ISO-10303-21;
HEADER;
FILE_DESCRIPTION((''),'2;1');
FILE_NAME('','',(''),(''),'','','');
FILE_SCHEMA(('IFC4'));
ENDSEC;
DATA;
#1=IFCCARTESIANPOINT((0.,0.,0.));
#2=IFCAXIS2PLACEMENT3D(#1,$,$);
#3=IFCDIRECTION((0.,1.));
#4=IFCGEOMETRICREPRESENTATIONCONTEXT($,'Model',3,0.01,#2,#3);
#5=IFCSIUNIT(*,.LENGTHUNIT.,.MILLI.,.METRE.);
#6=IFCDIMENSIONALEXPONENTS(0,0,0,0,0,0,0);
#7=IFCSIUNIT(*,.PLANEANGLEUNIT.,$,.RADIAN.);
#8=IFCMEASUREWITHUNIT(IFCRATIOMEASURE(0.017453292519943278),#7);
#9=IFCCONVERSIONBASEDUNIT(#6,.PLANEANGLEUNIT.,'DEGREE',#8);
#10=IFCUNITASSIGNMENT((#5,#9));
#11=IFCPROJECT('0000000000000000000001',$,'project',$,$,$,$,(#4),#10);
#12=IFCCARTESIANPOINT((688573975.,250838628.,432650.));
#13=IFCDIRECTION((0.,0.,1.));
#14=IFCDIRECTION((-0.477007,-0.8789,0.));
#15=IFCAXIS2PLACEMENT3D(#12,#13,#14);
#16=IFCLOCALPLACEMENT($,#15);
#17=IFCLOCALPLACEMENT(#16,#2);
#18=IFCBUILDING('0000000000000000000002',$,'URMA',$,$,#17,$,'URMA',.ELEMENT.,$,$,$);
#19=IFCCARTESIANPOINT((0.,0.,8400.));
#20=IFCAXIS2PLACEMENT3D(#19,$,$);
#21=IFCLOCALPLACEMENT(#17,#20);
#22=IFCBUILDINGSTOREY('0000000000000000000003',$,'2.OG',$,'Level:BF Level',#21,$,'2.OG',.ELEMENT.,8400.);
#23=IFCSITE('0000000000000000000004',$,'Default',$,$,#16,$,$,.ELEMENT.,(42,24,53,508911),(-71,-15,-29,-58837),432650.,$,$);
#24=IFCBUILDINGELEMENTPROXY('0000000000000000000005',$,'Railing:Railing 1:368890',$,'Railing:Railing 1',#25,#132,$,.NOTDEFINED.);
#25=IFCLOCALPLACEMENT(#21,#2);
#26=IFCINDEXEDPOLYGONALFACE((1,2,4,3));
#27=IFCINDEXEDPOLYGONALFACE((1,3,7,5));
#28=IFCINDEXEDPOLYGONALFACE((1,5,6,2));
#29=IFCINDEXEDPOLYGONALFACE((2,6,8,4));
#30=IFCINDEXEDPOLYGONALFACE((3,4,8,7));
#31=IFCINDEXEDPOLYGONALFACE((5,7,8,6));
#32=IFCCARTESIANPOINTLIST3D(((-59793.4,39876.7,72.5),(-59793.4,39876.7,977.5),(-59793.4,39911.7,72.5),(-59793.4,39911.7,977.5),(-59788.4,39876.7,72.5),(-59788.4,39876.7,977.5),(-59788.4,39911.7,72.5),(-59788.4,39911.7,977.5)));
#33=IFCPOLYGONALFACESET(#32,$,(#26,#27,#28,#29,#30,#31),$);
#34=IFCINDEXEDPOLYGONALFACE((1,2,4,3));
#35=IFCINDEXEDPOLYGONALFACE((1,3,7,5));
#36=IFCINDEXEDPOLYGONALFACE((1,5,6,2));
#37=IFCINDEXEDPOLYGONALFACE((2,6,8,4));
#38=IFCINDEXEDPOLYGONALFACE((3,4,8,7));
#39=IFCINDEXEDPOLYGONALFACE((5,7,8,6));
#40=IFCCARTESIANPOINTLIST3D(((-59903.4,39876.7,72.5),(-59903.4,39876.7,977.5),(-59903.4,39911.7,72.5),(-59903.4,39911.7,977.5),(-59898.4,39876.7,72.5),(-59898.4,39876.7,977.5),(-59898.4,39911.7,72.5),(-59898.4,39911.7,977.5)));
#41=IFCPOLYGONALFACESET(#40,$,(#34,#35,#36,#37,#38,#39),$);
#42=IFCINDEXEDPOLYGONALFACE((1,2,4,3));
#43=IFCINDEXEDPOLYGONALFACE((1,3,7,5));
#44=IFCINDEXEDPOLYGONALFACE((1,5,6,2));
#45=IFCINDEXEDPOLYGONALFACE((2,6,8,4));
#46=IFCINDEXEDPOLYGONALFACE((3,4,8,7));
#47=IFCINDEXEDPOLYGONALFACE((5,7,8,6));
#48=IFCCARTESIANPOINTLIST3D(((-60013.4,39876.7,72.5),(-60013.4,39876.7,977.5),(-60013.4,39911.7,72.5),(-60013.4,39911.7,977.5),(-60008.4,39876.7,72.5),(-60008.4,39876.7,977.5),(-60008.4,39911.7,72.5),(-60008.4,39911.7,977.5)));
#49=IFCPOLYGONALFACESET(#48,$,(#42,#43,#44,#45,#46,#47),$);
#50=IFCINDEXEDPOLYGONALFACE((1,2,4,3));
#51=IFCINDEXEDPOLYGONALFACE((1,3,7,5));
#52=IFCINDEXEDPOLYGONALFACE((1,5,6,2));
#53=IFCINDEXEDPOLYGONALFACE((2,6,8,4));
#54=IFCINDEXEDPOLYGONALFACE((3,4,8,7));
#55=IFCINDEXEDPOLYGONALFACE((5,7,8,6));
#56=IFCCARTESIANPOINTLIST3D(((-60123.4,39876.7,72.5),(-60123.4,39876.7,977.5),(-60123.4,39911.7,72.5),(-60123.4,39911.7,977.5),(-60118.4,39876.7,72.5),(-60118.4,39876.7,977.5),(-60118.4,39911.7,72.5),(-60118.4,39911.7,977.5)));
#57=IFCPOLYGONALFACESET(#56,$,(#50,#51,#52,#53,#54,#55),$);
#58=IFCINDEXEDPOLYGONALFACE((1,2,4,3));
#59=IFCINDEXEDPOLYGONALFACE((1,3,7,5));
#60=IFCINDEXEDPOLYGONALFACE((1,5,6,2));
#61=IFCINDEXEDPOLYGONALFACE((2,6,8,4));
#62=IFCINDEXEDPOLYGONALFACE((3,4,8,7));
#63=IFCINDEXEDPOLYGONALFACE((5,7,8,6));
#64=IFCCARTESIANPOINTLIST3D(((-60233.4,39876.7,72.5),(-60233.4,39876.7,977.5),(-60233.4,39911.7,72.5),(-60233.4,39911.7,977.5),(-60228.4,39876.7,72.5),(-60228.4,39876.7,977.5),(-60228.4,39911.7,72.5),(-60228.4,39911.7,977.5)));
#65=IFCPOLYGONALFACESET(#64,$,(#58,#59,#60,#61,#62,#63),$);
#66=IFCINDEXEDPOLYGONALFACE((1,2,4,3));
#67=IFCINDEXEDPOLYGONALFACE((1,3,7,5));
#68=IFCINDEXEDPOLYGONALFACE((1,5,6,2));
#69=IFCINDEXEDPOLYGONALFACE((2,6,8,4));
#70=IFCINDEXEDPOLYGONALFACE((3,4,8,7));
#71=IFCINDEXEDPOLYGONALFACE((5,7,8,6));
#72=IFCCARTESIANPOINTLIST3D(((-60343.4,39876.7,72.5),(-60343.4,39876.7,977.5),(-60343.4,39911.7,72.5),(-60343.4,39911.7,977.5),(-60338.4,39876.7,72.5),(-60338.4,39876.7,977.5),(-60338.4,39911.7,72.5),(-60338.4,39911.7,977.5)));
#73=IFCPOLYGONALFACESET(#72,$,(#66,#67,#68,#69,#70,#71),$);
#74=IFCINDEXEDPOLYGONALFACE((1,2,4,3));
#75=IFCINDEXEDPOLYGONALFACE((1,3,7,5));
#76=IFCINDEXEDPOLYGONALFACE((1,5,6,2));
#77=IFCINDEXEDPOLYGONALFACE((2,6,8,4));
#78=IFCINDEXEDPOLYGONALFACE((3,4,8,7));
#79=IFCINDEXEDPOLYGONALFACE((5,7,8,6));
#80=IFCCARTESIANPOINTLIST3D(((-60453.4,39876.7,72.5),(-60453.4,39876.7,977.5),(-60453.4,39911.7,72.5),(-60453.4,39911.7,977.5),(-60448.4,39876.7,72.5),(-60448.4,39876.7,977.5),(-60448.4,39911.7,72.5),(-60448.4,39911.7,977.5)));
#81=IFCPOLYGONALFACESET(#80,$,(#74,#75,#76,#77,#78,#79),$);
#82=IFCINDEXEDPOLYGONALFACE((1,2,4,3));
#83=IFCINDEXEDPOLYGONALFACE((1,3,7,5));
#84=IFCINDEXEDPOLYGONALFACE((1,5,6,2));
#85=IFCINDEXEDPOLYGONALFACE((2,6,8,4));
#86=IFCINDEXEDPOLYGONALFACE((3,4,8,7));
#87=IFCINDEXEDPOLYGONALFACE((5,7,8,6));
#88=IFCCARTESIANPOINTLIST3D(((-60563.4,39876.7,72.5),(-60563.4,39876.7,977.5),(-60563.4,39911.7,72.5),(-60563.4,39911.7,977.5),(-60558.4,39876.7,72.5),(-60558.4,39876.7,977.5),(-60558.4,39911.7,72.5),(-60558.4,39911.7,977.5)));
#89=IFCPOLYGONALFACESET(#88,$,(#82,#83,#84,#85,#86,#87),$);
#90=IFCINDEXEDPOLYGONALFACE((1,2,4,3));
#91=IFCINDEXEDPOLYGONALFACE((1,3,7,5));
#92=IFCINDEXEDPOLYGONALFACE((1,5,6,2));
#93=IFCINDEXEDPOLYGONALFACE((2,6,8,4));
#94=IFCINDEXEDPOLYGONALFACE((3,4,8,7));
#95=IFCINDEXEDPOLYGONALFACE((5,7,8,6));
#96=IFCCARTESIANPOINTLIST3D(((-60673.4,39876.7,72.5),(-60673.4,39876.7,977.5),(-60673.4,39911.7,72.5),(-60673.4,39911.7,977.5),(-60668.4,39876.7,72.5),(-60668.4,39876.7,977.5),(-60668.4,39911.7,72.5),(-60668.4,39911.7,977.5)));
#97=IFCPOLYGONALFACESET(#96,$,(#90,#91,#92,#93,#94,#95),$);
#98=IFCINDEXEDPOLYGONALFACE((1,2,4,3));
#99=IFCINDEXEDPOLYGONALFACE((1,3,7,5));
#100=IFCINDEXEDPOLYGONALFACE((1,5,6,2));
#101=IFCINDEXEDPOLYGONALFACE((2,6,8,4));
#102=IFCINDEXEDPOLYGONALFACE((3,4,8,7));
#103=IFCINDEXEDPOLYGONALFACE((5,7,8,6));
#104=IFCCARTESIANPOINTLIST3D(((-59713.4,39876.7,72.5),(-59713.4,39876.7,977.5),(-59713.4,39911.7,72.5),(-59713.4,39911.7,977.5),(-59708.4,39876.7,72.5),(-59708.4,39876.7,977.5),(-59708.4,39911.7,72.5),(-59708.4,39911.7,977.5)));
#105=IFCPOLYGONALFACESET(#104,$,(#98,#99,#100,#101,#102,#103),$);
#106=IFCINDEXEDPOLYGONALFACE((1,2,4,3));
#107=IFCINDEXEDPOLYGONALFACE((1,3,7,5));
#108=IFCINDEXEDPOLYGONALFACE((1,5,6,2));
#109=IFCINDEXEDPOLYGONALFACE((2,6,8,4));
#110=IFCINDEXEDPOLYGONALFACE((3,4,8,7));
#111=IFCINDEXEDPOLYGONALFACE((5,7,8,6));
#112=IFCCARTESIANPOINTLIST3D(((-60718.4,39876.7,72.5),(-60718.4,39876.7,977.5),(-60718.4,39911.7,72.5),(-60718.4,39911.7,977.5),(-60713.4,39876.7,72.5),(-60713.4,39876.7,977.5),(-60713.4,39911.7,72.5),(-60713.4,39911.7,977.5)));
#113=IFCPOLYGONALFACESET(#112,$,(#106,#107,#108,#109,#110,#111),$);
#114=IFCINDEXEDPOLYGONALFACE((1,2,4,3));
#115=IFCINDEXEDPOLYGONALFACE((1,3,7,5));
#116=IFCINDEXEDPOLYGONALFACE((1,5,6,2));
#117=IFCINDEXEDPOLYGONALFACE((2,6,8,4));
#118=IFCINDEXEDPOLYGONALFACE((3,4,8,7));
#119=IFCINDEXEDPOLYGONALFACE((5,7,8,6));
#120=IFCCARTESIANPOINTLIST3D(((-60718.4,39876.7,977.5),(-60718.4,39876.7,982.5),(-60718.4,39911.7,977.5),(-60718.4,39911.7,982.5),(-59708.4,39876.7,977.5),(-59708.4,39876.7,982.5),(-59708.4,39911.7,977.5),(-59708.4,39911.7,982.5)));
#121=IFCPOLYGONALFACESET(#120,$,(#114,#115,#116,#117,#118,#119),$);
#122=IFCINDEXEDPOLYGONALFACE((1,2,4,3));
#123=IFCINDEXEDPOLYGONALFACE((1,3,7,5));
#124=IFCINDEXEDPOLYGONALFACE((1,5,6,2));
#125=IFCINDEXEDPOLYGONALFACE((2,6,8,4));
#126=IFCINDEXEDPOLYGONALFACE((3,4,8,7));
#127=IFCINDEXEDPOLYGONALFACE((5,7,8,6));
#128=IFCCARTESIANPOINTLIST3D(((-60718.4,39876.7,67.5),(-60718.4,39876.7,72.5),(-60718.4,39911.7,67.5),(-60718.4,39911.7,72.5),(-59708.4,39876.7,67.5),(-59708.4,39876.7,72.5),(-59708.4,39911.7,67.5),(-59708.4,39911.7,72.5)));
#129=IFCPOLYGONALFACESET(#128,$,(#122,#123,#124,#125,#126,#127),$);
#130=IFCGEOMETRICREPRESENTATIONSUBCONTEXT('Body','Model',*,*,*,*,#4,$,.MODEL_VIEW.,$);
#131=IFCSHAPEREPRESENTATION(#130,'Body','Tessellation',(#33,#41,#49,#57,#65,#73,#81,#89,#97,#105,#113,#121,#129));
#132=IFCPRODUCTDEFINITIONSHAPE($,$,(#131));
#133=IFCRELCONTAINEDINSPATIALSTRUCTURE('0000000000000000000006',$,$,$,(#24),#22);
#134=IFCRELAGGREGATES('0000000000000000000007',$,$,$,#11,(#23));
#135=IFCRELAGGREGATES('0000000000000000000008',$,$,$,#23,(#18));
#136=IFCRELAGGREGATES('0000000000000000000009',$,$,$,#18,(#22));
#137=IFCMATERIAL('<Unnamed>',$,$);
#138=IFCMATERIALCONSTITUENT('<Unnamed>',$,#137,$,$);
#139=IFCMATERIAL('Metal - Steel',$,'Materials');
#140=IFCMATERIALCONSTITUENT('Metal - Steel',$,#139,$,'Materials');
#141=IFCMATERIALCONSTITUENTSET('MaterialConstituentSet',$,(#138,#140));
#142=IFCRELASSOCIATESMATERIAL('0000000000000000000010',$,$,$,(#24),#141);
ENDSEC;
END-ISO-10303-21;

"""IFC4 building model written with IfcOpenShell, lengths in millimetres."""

from ifc_helpers import new_model, entity, si_unit, converted_unit, direction, frame, origin, place, context, subcontext, project, spatial, indexed_curve, outline, extrude, material, constituent, constituent_set, element, save


model = new_model("IFC4")

# Units and contexts
model_context = context("Model", 3, precision=0.01, world=origin(), true_north=direction((0.0, 1.0)))
body_context = subcontext(model_context, "Body", "Model", "MODEL_VIEW")
ifc_project = project(units=[si_unit("LENGTHUNIT", "METRE", prefix="MILLI"), converted_unit("PLANEANGLEUNIT", "DEGREE", entity("IfcRatioMeasure", 0.017453292519943278), si_unit("PLANEANGLEUNIT", "RADIAN"), dimensions=[0, 0, 0, 0, 0, 0, 0])], contexts=[model_context])

# Site, building, storey
site_placement = place(None, frame((688573975.0, 250838628.0, 432650.0), z_axis=(0.0, 0.0, 1.0), x_axis=(-0.477007, -0.8789, 0.0)))
site = spatial("IfcSite", under=ifc_project, at=site_placement, Name="Default", CompositionType="ELEMENT", RefLatitude=(42, 24, 53, 508911), RefLongitude=(-71, -15, -29, -58837), RefElevation=432650.0)
building_placement = place(site_placement, origin())
building = spatial("IfcBuilding", under=site, at=building_placement, Name="URMA", LongName="URMA", CompositionType="ELEMENT")
storey_placement = place(building_placement, frame((0.0, 0.0, 8400.0)))
storey = spatial("IfcBuildingStorey", under=building, at=storey_placement, Name="2.OG", ObjectType="Level:BF Level", LongName="2.OG", CompositionType="ELEMENT", Elevation=8400.0)

# Building element proxy
ifc_material_1 = material(Name="<Unnamed>")
ifc_constituent_1 = constituent(ifc_material_1, Name="<Unnamed>")
ifc_material_2 = material(Name="Metal - Steel", Category="Materials")
ifc_constituent_2 = constituent(ifc_material_2, Name="Metal - Steel", Category="Materials")
ifc_constituent_set_1 = constituent_set(constituents=[ifc_constituent_1, ifc_constituent_2], Name="MaterialConstituentSet")
proxy_1_placement = place(storey_placement, origin())
element("IfcBuildingElementProxy", 1, at=proxy_1_placement, inside=storey, material=ifc_constituent_set_1, Name="Railing:Railing 1:368890", ObjectType="Railing:Railing 1", PredefinedType="NOTDEFINED", context=body_context, shape_type="SweptSolid", body=[
    extrude(outline(indexed_curve([(-17.5, -2.5), (17.5, -2.5), (17.5, 2.5), (-17.5, 2.5), (-17.5, -2.5)], self_intersect=False)), frame((-59790.9, 39894.2, 72.5), z_axis=(0.0, 0.0, 1.0), x_axis=(0.0, 1.0, 0.0)), (0.0, 0.0, 1.0), 905.0),
    extrude(outline(indexed_curve([(-17.5, -2.5), (17.5, -2.5), (17.5, 2.5), (-17.5, 2.5), (-17.5, -2.5)], self_intersect=False)), frame((-59900.9, 39894.2, 72.5), z_axis=(0.0, 0.0, 1.0), x_axis=(0.0, 1.0, 0.0)), (0.0, 0.0, 1.0), 905.0),
    extrude(outline(indexed_curve([(-17.5, -2.5), (17.5, -2.5), (17.5, 2.5), (-17.5, 2.5), (-17.5, -2.5)], self_intersect=False)), frame((-60010.9, 39894.2, 72.5), z_axis=(0.0, 0.0, 1.0), x_axis=(0.0, 1.0, 0.0)), (0.0, 0.0, 1.0), 905.0),
    extrude(outline(indexed_curve([(-17.5, -2.5), (17.5, -2.5), (17.5, 2.5), (-17.5, 2.5), (-17.5, -2.5)], self_intersect=False)), frame((-60120.9, 39894.2, 72.5), z_axis=(0.0, 0.0, 1.0), x_axis=(0.0, 1.0, 0.0)), (0.0, 0.0, 1.0), 905.0),
    extrude(outline(indexed_curve([(-17.5, -2.5), (17.5, -2.5), (17.5, 2.5), (-17.5, 2.5), (-17.5, -2.5)], self_intersect=False)), frame((-60230.9, 39894.2, 72.5), z_axis=(0.0, 0.0, 1.0), x_axis=(0.0, 1.0, 0.0)), (0.0, 0.0, 1.0), 905.0),
    extrude(outline(indexed_curve([(-17.5, -2.5), (17.5, -2.5), (17.5, 2.5), (-17.5, 2.5), (-17.5, -2.5)], self_intersect=False)), frame((-60340.9, 39894.2, 72.5), z_axis=(0.0, 0.0, 1.0), x_axis=(0.0, 1.0, 0.0)), (0.0, 0.0, 1.0), 905.0),
    extrude(outline(indexed_curve([(-17.5, -2.5), (17.5, -2.5), (17.5, 2.5), (-17.5, 2.5), (-17.5, -2.5)], self_intersect=False)), frame((-60450.9, 39894.2, 72.5), z_axis=(0.0, 0.0, 1.0), x_axis=(0.0, 1.0, 0.0)), (0.0, 0.0, 1.0), 905.0),
    extrude(outline(indexed_curve([(-17.5, -2.5), (17.5, -2.5), (17.5, 2.5), (-17.5, 2.5), (-17.5, -2.5)], self_intersect=False)), frame((-60560.9, 39894.2, 72.5), z_axis=(0.0, 0.0, 1.0), x_axis=(0.0, 1.0, 0.0)), (0.0, 0.0, 1.0), 905.0),
    extrude(outline(indexed_curve([(-17.5, -2.5), (17.5, -2.5), (17.5, 2.5), (-17.5, 2.5), (-17.5, -2.5)], self_intersect=False)), frame((-60670.9, 39894.2, 72.5), z_axis=(0.0, 0.0, 1.0), x_axis=(0.0, 1.0, 0.0)), (0.0, 0.0, 1.0), 905.0),
    extrude(outline(indexed_curve([(-17.5, -2.5), (17.5, -2.5), (17.5, 2.5), (-17.5, 2.5), (-17.5, -2.5)], self_intersect=False)), frame((-59710.9, 39894.2, 72.5), z_axis=(0.0, 0.0, 1.0), x_axis=(0.0, 1.0, 0.0)), (0.0, 0.0, 1.0), 905.0),
    extrude(outline(indexed_curve([(-17.5, -2.5), (17.5, -2.5), (17.5, 2.5), (-17.5, 2.5), (-17.5, -2.5)], self_intersect=False)), frame((-60715.9, 39894.2, 72.5), z_axis=(0.0, 0.0, 1.0), x_axis=(0.0, 1.0, 0.0)), (0.0, 0.0, 1.0), 905.0),
    extrude(outline(indexed_curve([(-505.0, -17.5), (505.0, -17.5), (505.0, 17.5), (-505.0, 17.5), (-505.0, -17.5)], self_intersect=False)), frame((-60213.4, 39894.2, 977.5)), (0.0, 0.0, 1.0), 5.0),
    extrude(outline(indexed_curve([(-505.0, -17.5), (505.0, -17.5), (505.0, 17.5), (-505.0, 17.5), (-505.0, -17.5)], self_intersect=False)), frame((-60213.4, 39894.2, 67.5)), (0.0, 0.0, 1.0), 5.0),
])

save(model, "model.ifc")
